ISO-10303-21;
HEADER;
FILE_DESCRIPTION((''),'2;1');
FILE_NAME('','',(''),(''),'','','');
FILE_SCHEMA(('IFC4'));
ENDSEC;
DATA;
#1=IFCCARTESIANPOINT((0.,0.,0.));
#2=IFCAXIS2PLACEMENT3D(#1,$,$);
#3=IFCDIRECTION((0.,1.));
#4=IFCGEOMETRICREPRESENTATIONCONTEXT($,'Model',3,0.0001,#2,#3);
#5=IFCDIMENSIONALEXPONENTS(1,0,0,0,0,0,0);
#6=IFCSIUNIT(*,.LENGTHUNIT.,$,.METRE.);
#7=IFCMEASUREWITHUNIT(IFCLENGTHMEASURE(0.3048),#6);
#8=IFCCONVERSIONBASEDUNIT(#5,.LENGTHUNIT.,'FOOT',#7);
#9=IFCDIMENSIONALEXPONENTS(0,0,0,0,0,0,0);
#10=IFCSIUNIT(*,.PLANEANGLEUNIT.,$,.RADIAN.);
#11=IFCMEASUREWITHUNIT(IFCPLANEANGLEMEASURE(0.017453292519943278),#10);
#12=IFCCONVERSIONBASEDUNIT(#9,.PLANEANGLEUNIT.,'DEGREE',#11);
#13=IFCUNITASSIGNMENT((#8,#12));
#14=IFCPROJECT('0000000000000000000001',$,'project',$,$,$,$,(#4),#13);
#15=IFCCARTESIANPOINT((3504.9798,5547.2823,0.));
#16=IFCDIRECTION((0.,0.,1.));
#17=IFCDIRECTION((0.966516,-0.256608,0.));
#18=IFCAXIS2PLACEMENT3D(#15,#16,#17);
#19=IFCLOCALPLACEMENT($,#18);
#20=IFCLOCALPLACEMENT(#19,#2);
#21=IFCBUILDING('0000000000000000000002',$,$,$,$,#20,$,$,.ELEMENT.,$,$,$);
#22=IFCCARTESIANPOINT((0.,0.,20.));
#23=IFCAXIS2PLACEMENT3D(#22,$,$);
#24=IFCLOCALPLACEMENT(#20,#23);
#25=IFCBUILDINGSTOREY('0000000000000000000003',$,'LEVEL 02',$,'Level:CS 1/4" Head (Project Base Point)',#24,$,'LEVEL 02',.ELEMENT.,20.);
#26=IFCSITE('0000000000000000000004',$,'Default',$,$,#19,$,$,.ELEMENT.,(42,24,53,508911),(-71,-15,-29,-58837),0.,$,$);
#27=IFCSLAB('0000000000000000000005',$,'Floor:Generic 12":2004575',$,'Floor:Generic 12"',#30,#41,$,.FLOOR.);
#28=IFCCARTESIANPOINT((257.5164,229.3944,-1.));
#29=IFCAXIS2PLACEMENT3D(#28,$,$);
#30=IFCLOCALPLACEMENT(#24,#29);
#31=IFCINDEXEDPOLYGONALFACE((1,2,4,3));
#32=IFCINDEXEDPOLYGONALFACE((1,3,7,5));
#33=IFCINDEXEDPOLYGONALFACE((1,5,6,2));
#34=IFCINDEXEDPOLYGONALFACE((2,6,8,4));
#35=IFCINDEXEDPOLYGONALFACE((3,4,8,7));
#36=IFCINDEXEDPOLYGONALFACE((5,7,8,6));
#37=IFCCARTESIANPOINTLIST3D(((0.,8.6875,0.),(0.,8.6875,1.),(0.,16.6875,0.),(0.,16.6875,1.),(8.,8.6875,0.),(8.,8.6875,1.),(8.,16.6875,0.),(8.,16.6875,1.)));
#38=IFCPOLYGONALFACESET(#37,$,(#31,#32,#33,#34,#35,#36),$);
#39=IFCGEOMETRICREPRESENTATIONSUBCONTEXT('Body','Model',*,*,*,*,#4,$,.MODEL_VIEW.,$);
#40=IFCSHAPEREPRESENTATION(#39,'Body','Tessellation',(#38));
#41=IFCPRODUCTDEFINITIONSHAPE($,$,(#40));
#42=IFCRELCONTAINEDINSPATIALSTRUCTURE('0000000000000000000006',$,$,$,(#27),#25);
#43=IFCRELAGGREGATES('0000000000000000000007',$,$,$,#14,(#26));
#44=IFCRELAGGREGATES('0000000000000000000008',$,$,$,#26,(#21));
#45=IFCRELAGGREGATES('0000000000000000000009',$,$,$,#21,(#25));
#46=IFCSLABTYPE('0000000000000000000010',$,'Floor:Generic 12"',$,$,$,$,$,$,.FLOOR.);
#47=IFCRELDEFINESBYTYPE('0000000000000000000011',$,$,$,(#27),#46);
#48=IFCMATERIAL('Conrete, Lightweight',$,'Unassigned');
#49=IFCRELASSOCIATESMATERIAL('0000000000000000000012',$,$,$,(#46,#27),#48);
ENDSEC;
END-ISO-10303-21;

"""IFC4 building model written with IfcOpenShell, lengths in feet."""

from ifc_helpers import new_model, entity, si_unit, converted_unit, direction, frame, origin, origin_2d_with_axis, place, context, subcontext, project, spatial, rectangle, extrude, material, type_object, element, save


model = new_model("IFC4")

# Units and contexts
model_context = context("Model", 3, precision=0.0001, world=origin(), true_north=direction((0.0, 1.0)))
body_context = subcontext(model_context, "Body", "Model", "MODEL_VIEW")
ifc_project = project(units=[converted_unit("LENGTHUNIT", "FOOT", entity("IfcLengthMeasure", 0.3048), si_unit("LENGTHUNIT", "METRE"), dimensions=[1, 0, 0, 0, 0, 0, 0]), converted_unit("PLANEANGLEUNIT", "DEGREE", entity("IfcPlaneAngleMeasure", 0.017453292519943278), si_unit("PLANEANGLEUNIT", "RADIAN"), dimensions=[0, 0, 0, 0, 0, 0, 0])], contexts=[model_context])

# Site, building, storey
site_placement = place(None, frame((3504.9798, 5547.2823, 0.0), z_axis=(0.0, 0.0, 1.0), x_axis=(0.966516, -0.256608, 0.0)))
site = spatial("IfcSite", under=ifc_project, at=site_placement, Name="Default", CompositionType="ELEMENT", RefLatitude=(42, 24, 53, 508911), RefLongitude=(-71, -15, -29, -58837), RefElevation=0.0)
building_placement = place(site_placement, origin())
building = spatial("IfcBuilding", under=site, at=building_placement, CompositionType="ELEMENT")
storey_placement = place(building_placement, frame((0.0, 0.0, 20.0)))
storey = spatial("IfcBuildingStorey", under=building, at=storey_placement, Name="LEVEL 02", ObjectType="Level:CS 1/4\" Head (Project Base Point)", LongName="LEVEL 02", CompositionType="ELEMENT", Elevation=20.0)

# Slab
ifc_material_1 = material(Name="Conrete, Lightweight", Category="Unassigned")
slab_type = type_object("IfcSlabType", Name="Floor:Generic 12\"", PredefinedType="FLOOR", material=ifc_material_1)
slab_1_placement = place(storey_placement, frame((257.5164, 229.3944, -1.0)))
element("IfcSlab", 1, at=slab_1_placement, inside=storey, type_object=slab_type, material=ifc_material_1, Name="Floor:Generic 12\":2004575", ObjectType="Floor:Generic 12\"", PredefinedType="FLOOR", context=body_context, shape_type="SweptSolid", body=[
    extrude(rectangle(XDim=8.0, YDim=8.0, at=origin_2d_with_axis()), frame((4.0, 12.6875, 1.0), z_axis=(0.0, 0.0, -1.0), x_axis=(-1.0, 0.0, 0.0)), (0.0, 0.0, 1.0), 1.0),
])

save(model, "model.ifc")
